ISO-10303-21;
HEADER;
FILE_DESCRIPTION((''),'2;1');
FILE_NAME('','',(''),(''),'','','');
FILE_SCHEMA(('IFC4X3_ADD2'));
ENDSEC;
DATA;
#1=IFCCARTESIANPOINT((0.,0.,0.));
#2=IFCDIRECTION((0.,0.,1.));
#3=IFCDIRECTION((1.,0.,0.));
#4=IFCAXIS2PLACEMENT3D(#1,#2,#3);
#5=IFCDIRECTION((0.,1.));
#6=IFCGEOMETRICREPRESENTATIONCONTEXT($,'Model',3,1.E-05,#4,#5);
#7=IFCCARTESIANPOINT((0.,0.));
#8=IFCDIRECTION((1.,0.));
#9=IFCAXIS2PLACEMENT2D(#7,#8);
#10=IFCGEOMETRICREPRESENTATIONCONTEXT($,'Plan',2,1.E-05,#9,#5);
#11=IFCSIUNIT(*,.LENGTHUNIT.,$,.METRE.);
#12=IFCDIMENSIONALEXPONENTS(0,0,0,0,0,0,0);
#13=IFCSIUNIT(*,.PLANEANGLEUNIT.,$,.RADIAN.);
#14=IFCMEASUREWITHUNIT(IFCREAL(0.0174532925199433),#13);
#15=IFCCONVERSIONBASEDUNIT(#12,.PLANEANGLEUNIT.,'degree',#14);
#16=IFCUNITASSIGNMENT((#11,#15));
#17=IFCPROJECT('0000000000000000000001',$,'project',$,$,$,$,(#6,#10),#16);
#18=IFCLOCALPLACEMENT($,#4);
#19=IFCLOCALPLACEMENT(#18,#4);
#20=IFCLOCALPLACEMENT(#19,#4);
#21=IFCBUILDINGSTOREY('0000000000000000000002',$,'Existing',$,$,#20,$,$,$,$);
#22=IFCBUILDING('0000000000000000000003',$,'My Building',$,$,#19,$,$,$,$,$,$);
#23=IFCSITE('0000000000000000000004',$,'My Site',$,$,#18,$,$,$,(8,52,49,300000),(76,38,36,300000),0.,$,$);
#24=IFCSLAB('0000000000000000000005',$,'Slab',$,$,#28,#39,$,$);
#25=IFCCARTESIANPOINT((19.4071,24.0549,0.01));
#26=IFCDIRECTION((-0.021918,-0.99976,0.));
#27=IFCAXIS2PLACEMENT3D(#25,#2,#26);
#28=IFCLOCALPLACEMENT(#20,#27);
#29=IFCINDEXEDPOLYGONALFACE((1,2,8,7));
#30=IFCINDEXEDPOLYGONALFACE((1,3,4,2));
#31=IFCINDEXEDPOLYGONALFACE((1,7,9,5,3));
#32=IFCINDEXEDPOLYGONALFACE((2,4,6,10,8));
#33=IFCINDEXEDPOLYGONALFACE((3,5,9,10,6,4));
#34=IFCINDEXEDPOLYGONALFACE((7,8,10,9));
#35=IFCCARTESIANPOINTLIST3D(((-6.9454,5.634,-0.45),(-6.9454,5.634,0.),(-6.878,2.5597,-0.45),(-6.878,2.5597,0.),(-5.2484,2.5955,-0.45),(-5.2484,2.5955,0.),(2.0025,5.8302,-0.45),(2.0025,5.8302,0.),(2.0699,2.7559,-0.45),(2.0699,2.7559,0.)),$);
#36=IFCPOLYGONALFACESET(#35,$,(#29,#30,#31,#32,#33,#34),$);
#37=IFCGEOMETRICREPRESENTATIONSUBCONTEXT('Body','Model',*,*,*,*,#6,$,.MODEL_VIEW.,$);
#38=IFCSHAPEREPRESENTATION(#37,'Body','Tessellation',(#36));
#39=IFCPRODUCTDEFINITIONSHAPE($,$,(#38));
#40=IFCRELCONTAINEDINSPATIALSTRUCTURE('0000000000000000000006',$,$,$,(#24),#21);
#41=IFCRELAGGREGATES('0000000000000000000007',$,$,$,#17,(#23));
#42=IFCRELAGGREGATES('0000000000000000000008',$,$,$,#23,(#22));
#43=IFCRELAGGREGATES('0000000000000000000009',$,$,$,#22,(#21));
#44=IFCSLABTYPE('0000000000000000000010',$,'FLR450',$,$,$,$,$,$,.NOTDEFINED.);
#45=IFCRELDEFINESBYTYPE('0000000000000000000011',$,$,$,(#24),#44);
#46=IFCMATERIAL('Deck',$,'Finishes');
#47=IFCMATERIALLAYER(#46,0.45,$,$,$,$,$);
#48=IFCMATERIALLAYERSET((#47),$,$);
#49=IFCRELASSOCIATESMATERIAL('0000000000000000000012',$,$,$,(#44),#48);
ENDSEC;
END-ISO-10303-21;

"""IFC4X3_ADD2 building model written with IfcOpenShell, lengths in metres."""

from ifc_helpers import new_model, entity, si_unit, converted_unit, direction, frame, origin_with_axes, origin_2d_with_axis, place, context, subcontext, project, spatial, indexed_curve, outline, extrude, material, layer, layer_set, type_object, element, save


model = new_model("IFC4X3_ADD2")

# Units and contexts
model_context = context("Model", 3, precision=1e-05, world=origin_with_axes(), true_north=direction((0.0, 1.0)))
plan_context = context("Plan", 2, precision=1e-05, world=origin_2d_with_axis(), true_north=direction((0.0, 1.0)))
body_context = subcontext(model_context, "Body", "Model", "MODEL_VIEW")
ifc_project = project(units=[si_unit("LENGTHUNIT", "METRE"), converted_unit("PLANEANGLEUNIT", "degree", entity("IfcReal", 0.0174532925199433), si_unit("PLANEANGLEUNIT", "RADIAN"), dimensions=[0, 0, 0, 0, 0, 0, 0])], contexts=[model_context, plan_context])

# Site, building, storey
site_placement = place(None, origin_with_axes())
site = spatial("IfcSite", under=ifc_project, at=site_placement, Name="My Site", RefLatitude=(8, 52, 49, 300000), RefLongitude=(76, 38, 36, 300000), RefElevation=0.0)
building_placement = place(site_placement, origin_with_axes())
building = spatial("IfcBuilding", under=site, at=building_placement, Name="My Building")
storey_placement = place(building_placement, origin_with_axes())
storey = spatial("IfcBuildingStorey", under=building, at=storey_placement, Name="Existing")

# Slab
ifc_material = material(Name="Deck", Category="Finishes")
ifc_layer = layer(ifc_material, 0.45)
ifc_layer_set = layer_set([ifc_layer])
slab_type = type_object("IfcSlabType", Name="FLR450", PredefinedType="NOTDEFINED", material=ifc_layer_set)
slab_placement = place(storey_placement, frame((19.4071, 24.0549, 0.01), z_axis=(0.0, 0.0, 1.0), x_axis=(-0.021918, -0.99976, 0.0)))
element("IfcSlab", 1, at=slab_placement, inside=storey, type_object=slab_type, Name="Slab", context=body_context, shape_type="SweptSolid", body=[
    extrude(outline(indexed_curve([(-6.878, 2.5597), (-5.2484, 2.5955), (2.0699, 2.7559), (2.0025, 5.8302), (-6.9454, 5.634), (-6.878, 2.5597)])), frame((0.0, 0.0, -0.45), z_axis=(0.0, 0.0, 1.0), x_axis=(1.0, 0.0, 0.0)), (0.0, 0.0, 1.0), 0.45),
])

save(model, "model.ifc")
